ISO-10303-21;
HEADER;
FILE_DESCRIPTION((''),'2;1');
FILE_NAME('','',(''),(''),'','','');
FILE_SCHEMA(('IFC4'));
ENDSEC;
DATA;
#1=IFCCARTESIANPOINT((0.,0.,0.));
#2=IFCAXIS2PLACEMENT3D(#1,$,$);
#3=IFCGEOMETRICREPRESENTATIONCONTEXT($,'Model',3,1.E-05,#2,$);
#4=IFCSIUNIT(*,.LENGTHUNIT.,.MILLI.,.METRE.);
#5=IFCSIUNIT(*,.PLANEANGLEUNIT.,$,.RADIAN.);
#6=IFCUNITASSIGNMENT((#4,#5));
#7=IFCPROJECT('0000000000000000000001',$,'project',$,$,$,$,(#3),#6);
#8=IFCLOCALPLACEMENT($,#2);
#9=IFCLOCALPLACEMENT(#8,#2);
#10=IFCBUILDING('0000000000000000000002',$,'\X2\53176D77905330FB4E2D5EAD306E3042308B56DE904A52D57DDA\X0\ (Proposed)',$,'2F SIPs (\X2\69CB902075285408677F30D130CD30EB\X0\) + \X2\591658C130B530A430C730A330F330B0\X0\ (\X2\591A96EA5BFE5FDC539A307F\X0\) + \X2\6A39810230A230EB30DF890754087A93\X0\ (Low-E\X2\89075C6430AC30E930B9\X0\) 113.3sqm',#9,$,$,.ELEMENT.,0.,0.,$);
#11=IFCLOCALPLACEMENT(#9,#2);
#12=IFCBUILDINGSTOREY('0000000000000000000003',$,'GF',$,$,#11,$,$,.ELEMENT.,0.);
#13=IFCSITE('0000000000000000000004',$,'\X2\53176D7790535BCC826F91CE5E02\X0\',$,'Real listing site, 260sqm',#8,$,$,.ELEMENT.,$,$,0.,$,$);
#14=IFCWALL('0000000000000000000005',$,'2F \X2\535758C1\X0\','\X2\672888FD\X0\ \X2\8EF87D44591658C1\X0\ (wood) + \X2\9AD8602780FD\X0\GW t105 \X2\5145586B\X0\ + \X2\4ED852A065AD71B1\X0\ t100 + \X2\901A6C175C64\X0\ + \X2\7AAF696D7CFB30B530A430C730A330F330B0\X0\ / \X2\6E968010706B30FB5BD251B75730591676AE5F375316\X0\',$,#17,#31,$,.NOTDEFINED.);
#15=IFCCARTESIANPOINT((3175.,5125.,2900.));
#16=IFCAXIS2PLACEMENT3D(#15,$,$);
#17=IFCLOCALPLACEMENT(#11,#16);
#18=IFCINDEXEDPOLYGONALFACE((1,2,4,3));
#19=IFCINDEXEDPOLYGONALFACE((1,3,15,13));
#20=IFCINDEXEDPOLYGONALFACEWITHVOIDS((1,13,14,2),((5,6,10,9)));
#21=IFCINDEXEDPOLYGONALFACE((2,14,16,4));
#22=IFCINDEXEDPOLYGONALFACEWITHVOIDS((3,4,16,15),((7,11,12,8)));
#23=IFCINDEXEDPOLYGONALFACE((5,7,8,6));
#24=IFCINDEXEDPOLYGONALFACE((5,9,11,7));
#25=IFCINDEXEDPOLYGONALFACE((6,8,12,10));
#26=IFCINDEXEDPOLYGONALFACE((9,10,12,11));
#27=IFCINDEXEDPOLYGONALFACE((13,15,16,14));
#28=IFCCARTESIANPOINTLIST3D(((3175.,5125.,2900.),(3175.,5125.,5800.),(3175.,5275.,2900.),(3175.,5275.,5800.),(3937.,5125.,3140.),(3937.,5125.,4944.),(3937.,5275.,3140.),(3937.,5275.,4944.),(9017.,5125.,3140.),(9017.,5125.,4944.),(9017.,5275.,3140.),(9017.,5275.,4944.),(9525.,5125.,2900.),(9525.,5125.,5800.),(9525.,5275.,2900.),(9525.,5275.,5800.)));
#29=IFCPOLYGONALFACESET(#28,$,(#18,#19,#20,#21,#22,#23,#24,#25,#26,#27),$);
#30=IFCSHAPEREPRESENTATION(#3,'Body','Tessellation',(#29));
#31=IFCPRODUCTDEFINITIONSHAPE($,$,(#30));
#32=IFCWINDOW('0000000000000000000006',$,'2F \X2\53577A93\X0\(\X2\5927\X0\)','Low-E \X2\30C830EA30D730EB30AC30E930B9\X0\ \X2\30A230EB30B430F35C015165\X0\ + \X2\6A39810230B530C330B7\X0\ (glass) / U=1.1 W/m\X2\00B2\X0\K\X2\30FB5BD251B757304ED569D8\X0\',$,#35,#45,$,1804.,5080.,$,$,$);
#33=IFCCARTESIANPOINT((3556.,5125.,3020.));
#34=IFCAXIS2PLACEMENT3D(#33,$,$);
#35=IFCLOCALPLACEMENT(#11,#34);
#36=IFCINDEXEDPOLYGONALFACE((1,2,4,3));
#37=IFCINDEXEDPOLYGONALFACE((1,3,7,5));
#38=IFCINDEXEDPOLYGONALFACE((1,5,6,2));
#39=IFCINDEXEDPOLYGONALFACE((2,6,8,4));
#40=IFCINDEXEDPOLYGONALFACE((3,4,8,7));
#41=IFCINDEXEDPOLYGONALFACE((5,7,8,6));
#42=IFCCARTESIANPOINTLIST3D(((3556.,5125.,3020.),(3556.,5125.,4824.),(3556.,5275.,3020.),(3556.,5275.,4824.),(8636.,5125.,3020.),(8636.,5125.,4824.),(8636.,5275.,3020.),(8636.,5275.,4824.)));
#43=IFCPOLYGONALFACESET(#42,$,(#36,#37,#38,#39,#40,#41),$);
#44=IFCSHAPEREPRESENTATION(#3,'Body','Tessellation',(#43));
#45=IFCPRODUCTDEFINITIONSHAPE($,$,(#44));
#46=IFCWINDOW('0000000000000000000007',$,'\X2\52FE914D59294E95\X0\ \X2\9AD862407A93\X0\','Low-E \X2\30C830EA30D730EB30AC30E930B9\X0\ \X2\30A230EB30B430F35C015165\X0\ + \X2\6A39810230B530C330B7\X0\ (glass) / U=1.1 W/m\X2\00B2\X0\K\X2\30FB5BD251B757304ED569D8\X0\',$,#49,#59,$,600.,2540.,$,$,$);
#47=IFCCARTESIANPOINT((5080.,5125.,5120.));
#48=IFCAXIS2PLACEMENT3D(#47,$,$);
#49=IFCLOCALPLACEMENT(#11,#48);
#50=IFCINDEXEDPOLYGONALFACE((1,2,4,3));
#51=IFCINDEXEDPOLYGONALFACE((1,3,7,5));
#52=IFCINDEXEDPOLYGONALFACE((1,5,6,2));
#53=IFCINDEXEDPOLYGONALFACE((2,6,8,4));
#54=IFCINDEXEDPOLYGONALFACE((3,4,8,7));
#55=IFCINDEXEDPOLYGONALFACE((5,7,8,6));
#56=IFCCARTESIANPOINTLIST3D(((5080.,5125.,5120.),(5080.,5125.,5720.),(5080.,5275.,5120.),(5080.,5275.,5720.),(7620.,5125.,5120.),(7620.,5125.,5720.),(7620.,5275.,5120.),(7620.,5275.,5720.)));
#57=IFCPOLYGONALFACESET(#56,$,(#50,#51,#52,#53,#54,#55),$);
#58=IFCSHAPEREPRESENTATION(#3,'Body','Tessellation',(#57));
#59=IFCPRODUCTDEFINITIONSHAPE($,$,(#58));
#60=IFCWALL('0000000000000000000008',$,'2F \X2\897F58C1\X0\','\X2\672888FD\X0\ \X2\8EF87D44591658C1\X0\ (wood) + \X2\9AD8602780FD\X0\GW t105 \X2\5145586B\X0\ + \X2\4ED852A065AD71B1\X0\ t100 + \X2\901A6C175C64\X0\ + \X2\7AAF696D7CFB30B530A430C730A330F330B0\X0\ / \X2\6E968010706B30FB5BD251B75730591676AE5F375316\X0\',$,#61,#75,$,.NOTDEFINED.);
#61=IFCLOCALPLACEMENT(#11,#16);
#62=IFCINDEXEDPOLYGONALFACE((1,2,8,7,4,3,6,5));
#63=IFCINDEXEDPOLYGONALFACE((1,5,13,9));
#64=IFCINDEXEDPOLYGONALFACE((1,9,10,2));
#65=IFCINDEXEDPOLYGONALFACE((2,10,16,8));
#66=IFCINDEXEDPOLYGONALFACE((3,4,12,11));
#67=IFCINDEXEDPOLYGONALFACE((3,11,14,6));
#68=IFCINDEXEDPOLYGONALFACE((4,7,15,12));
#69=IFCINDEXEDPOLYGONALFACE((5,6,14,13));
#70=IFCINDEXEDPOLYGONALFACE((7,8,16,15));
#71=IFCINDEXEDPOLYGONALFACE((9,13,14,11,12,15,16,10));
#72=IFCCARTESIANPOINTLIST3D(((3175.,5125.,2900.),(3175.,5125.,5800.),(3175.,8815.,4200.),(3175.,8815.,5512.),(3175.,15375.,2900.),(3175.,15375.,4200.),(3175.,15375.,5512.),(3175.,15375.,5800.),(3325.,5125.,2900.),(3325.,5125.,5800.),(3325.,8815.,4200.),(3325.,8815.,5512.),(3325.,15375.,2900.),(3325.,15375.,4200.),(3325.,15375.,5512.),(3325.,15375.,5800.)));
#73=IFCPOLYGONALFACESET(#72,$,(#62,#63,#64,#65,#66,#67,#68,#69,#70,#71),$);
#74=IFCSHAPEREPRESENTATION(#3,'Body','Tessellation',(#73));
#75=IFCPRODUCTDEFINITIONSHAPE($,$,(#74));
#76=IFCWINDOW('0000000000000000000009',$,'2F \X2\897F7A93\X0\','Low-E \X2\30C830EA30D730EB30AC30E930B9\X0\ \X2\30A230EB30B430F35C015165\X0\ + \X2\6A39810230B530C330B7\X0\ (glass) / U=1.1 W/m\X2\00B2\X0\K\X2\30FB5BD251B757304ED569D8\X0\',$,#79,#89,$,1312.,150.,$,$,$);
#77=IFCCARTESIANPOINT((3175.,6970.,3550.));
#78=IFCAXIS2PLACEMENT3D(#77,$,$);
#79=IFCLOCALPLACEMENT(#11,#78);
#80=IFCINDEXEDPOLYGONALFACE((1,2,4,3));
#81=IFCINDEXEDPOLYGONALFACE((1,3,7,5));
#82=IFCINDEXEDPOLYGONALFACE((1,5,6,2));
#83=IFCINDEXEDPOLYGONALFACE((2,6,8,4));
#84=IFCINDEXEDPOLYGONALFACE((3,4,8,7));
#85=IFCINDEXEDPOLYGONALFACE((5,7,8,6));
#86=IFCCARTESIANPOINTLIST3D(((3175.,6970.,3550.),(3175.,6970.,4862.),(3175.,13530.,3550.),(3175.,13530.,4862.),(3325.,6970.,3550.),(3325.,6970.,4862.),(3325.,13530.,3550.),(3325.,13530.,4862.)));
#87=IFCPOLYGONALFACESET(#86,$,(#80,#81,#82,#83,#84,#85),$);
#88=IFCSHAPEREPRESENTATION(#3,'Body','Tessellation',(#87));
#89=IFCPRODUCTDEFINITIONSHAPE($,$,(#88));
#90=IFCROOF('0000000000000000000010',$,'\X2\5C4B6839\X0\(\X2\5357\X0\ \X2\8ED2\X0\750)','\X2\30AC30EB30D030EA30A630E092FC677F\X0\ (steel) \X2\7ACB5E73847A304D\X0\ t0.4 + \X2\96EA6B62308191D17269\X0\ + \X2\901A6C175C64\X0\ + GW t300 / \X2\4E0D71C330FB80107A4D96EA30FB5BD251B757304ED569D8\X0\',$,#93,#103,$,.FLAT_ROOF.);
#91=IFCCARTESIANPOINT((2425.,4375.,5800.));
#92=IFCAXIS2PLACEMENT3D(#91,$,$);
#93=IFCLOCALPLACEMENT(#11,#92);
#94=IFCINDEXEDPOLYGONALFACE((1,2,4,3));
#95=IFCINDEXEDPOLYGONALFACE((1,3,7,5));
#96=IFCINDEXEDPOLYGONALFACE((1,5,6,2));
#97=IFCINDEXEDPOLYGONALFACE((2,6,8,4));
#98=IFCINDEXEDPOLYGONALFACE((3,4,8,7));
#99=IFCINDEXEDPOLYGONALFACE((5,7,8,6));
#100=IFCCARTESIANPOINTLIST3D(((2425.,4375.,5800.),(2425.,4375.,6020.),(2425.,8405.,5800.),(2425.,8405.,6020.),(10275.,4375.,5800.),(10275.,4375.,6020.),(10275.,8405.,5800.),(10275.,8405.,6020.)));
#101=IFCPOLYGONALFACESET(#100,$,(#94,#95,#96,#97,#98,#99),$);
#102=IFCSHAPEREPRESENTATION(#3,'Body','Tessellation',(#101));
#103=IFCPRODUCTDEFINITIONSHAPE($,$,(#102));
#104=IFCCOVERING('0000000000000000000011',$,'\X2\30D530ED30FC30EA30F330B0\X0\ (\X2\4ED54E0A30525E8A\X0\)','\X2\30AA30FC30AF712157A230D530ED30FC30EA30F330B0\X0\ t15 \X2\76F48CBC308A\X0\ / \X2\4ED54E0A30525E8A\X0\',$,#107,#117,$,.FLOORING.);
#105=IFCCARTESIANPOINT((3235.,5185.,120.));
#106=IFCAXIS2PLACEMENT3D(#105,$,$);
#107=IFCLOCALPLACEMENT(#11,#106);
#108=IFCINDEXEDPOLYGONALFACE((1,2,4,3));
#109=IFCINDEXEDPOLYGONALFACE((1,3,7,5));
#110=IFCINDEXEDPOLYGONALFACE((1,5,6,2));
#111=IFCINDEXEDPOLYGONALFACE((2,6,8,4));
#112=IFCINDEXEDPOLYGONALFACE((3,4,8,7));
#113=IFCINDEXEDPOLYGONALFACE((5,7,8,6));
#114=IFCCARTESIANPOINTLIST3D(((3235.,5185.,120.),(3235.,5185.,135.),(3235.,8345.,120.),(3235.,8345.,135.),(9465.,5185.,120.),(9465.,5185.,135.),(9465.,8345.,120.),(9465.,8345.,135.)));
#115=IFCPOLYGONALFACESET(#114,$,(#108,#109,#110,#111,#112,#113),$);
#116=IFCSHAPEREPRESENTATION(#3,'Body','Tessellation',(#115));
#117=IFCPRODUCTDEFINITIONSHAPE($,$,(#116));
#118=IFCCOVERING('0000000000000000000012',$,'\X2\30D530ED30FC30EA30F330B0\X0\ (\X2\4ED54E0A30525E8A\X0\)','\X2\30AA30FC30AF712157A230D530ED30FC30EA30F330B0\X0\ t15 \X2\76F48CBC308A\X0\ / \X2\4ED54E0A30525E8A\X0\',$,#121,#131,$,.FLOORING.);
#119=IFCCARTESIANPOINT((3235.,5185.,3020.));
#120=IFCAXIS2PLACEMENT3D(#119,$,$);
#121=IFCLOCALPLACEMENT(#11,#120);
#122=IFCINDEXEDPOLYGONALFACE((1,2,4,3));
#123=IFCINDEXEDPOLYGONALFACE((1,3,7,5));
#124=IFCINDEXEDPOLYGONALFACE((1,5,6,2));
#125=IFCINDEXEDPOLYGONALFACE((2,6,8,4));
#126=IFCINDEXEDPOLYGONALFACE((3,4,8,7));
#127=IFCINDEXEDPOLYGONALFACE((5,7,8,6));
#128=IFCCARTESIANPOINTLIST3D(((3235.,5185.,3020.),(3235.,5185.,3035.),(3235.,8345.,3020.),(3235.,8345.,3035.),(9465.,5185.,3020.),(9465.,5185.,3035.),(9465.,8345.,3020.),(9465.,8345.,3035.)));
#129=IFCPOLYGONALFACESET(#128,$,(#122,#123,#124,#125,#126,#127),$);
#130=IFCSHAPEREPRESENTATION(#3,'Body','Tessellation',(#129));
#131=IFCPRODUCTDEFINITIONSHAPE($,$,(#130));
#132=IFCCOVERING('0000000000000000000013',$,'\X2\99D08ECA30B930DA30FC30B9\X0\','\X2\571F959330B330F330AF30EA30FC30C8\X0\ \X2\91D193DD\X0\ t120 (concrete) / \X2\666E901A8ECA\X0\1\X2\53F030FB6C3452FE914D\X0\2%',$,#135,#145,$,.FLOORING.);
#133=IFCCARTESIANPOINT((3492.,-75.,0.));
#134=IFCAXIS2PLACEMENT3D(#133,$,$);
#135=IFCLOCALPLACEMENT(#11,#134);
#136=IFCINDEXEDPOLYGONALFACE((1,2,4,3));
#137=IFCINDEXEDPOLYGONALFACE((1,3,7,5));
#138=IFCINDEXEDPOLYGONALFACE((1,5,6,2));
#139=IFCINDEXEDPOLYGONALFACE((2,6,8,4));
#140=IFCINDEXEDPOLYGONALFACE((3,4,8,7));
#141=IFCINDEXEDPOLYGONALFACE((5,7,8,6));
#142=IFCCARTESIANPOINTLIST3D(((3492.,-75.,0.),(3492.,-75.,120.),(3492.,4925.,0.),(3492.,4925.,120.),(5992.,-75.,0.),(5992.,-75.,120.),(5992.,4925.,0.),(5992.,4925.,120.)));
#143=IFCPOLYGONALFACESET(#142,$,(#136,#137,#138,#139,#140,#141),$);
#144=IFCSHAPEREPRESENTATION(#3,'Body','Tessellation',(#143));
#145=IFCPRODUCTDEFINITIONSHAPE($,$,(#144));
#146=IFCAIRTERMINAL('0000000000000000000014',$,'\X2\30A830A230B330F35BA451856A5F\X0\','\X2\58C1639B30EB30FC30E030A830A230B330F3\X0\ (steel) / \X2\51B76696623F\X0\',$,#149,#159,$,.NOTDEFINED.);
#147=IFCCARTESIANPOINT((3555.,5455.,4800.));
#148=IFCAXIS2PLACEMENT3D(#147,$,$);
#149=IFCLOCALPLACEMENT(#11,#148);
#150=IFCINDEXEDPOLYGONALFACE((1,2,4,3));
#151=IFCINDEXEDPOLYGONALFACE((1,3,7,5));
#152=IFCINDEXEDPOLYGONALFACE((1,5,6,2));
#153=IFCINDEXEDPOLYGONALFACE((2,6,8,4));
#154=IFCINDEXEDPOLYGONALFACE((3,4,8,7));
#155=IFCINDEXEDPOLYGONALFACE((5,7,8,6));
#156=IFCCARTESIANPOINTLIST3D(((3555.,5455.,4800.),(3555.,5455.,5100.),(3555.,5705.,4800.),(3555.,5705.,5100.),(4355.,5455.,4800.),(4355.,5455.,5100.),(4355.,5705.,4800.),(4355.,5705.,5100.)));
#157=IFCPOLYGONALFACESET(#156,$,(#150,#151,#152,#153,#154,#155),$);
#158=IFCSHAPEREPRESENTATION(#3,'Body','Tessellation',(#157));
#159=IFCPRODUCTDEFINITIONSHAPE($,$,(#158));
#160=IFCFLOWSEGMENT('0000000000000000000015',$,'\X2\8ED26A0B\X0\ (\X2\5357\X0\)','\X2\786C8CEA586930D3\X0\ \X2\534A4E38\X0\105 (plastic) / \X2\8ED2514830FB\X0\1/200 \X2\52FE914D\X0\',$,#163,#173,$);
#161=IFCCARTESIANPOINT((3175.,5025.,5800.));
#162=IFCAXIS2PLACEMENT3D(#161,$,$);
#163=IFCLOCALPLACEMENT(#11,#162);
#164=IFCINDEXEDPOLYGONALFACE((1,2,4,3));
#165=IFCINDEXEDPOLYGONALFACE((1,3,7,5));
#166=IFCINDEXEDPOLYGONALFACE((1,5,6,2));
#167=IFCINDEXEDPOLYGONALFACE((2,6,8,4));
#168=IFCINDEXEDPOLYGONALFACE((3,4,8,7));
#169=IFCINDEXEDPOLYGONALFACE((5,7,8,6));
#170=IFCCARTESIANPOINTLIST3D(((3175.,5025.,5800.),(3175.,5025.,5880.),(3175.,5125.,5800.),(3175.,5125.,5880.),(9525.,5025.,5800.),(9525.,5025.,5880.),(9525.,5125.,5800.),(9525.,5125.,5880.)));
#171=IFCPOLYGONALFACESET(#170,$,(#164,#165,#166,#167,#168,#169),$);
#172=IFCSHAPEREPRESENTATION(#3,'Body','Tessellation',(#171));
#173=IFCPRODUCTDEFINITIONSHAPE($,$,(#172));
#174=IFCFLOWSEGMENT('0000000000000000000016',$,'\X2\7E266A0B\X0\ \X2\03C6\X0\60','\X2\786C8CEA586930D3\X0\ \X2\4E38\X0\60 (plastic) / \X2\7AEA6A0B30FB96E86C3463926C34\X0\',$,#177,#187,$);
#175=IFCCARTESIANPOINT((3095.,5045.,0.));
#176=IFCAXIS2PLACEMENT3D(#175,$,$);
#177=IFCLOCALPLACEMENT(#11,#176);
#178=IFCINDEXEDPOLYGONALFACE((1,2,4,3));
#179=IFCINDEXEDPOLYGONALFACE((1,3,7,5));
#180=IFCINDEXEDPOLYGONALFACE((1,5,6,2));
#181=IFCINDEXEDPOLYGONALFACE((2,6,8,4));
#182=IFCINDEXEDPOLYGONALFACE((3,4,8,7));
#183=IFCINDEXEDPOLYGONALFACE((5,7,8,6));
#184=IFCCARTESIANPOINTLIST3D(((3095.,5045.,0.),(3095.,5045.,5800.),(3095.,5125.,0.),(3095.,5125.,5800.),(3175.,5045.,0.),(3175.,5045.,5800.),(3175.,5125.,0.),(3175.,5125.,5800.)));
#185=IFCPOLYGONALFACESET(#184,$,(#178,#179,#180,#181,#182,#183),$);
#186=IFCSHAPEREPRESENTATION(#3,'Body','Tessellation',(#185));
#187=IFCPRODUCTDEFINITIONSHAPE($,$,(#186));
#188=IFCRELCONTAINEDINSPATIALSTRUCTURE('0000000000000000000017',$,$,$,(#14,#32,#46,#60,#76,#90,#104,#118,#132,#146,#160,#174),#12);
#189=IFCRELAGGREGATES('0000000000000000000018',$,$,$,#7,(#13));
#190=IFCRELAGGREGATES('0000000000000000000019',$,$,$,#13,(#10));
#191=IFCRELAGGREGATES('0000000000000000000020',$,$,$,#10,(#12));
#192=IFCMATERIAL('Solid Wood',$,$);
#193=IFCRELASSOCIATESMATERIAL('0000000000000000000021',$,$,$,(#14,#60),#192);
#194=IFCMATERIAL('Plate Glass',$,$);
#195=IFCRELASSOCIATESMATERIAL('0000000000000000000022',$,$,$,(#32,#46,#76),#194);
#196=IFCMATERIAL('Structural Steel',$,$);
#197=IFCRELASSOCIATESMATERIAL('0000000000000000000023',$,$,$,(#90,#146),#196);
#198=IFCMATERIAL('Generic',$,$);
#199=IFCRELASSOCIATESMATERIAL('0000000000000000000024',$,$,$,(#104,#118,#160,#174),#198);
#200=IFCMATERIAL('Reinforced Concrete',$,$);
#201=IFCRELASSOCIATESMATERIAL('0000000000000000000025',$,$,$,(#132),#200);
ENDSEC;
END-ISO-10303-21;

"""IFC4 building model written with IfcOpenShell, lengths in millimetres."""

from ifc_helpers import new_model, si_unit, frame, frame_2d, origin, place, context, project, spatial, rectangle, extrude, material, element, fill, save


model = new_model("IFC4")

# Units and contexts
model_context = context("Model", 3, precision=1e-05, world=origin())
ifc_project = project(units=[si_unit("LENGTHUNIT", "METRE", prefix="MILLI"), si_unit("PLANEANGLEUNIT", "RADIAN")], contexts=[model_context])

# Site, building, storey
site_placement = place(None, origin())
site = spatial("IfcSite", under=ifc_project, at=site_placement, Name="北海道富良野市", ObjectType="Real listing site, 260sqm", CompositionType="ELEMENT", RefElevation=0.0)
building_placement = place(site_placement, origin())
building = spatial("IfcBuilding", under=site, at=building_placement, Name="北海道・中庭のある回遊動線 (Proposed)", ObjectType="2F SIPs (構造用合板パネル) + 外壁サイディング (多雪対応厚み) + 樹脂アルミ複合窓 (Low-E複層ガラス) 113.3sqm", CompositionType="ELEMENT", ElevationOfRefHeight=0.0, ElevationOfTerrain=0.0)
storey_placement = place(building_placement, origin())
storey = spatial("IfcBuildingStorey", under=building, at=storey_placement, Name="GF", CompositionType="ELEMENT", Elevation=0.0)

# Shared definitions
ifc_material_1 = material(Name="Solid Wood")

# Shared definitions
ifc_material_2 = material(Name="Reinforced Concrete")

# Shared definitions
ifc_material_3 = material(Name="Plate Glass")

# Wall, openings, windows
wall_1_placement = place(storey_placement, frame((3175.0, 5125.0, 2900.0)))
wall_1 = element("IfcWall", 1, at=wall_1_placement, inside=storey, material=ifc_material_1, Name="2F 南壁", Description="木製 軸組外壁 (wood) + 高性能GW t105 充填 + 付加断熱 t100 + 通気層 + 窯業系サイディング / 準耐火・寒冷地外皮強化", PredefinedType="NOTDEFINED", context=model_context, shape_type="SweptSolid", body=[
    extrude(rectangle(XDim=6350.0, YDim=150.0, at=frame_2d((3175.0, 75.0))), frame((3175.0, 5125.0, 2900.0)), (0.0, 0.0, 1.0), 2900.0),
])
opening_1_placement = place(storey_placement, frame((3556.0, 5125.0, 3020.0)))
opening_1 = element("IfcOpeningElement", 2, at=opening_1_placement, cuts=wall_1, PredefinedType="NOTDEFINED", context=model_context, shape_type="SweptSolid", body=[
    extrude(rectangle(XDim=5080.0, YDim=150.0, at=frame_2d((2540.0, 75.0))), frame((3556.0, 5125.0, 3020.0)), (0.0, 0.0, 1.0), 1804.0),
])
opening_2_placement = place(storey_placement, frame((5080.0, 5125.0, 5120.0)))
opening_2 = element("IfcOpeningElement", 3, at=opening_2_placement, cuts=wall_1, PredefinedType="NOTDEFINED", context=model_context, shape_type="SweptSolid", body=[
    extrude(rectangle(XDim=2540.0, YDim=150.0, at=frame_2d((1270.0, 75.0))), frame((5080.0, 5125.0, 5120.0)), (0.0, 0.0, 1.0), 600.0),
])
window_1_placement = place(storey_placement, frame((3556.0, 5125.0, 3020.0)))
window_1 = element("IfcWindow", 4, at=window_1_placement, inside=storey, material=ifc_material_3, Name="2F 南窓(大)", Description="Low-E トリプルガラス アルゴン封入 + 樹脂サッシ (glass) / U=1.1 W/m²K・寒冷地仕様", OverallHeight=1804.0, OverallWidth=5080.0, context=model_context, shape_type="SweptSolid", body=[
    extrude(rectangle(XDim=5080.0, YDim=150.0, at=frame_2d((2540.0, 75.0))), frame((3556.0, 5125.0, 3020.0)), (0.0, 0.0, 1.0), 1804.0),
])
fill(opening_1, window_1)
window_2_placement = place(storey_placement, frame((5080.0, 5125.0, 5120.0)))
window_2 = element("IfcWindow", 5, at=window_2_placement, inside=storey, material=ifc_material_3, Name="勾配天井 高所窓", Description="Low-E トリプルガラス アルゴン封入 + 樹脂サッシ (glass) / U=1.1 W/m²K・寒冷地仕様", OverallHeight=600.0, OverallWidth=2540.0, context=model_context, shape_type="SweptSolid", body=[
    extrude(rectangle(XDim=2540.0, YDim=150.0, at=frame_2d((1270.0, 75.0))), frame((5080.0, 5125.0, 5120.0)), (0.0, 0.0, 1.0), 600.0),
])
fill(opening_2, window_2)

# Wall, opening, window
wall_2_placement = place(storey_placement, frame((3175.0, 5125.0, 2900.0)))
wall_2 = element("IfcWall", 6, at=wall_2_placement, inside=storey, material=ifc_material_1, Name="2F 西壁", Description="木製 軸組外壁 (wood) + 高性能GW t105 充填 + 付加断熱 t100 + 通気層 + 窯業系サイディング / 準耐火・寒冷地外皮強化", PredefinedType="NOTDEFINED", context=model_context, shape_type="SweptSolid", body=[
    extrude(rectangle(XDim=150.0, YDim=10250.0, at=frame_2d((75.0, 5125.0))), frame((3175.0, 5125.0, 2900.0)), (0.0, 0.0, 1.0), 2900.0),
])
opening_3_placement = place(storey_placement, frame((3175.0, 6970.0, 3550.0)))
opening_3 = element("IfcOpeningElement", 7, at=opening_3_placement, cuts=wall_2, PredefinedType="NOTDEFINED", context=model_context, shape_type="SweptSolid", body=[
    extrude(rectangle(XDim=150.0, YDim=6560.0, at=frame_2d((75.0, 3280.0))), frame((3175.0, 6970.0, 3550.0)), (0.0, 0.0, 1.0), 1312.0),
])
window_3_placement = place(storey_placement, frame((3175.0, 6970.0, 3550.0)))
window_3 = element("IfcWindow", 8, at=window_3_placement, inside=storey, material=ifc_material_3, Name="2F 西窓", Description="Low-E トリプルガラス アルゴン封入 + 樹脂サッシ (glass) / U=1.1 W/m²K・寒冷地仕様", OverallHeight=1312.0, OverallWidth=150.0, context=model_context, shape_type="SweptSolid", body=[
    extrude(rectangle(XDim=150.0, YDim=6560.0, at=frame_2d((75.0, 3280.0))), frame((3175.0, 6970.0, 3550.0)), (0.0, 0.0, 1.0), 1312.0),
])
fill(opening_3, window_3)

# Roof
ifc_material_4 = material(Name="Structural Steel")
for number, where, name in (
    (9, (2425.0, 4375.0, 5800.0), "屋根(南 軒750)"),
):
    element("IfcRoof", number, at=place(storey_placement, frame(where)), inside=storey, material=ifc_material_4, Name=name, Description="ガルバリウム鋼板 (steel) 立平葺き t0.4 + 雪止め金物 + 通気層 + GW t300 / 不燃・耐積雪・寒冷地仕様", PredefinedType="FLAT_ROOF", context=model_context, shape_type="SweptSolid", body=[
        extrude(rectangle(XDim=7850.0, YDim=4030.0, at=frame_2d((3925.0, 2015.0))), frame((2425.0, 4375.0, 5800.0)), (0.0, 0.0, 1.0), 220.0),
    ])

# Coverings
ifc_material_5 = material(Name="Generic")
covering_1_placement = place(storey_placement, frame((3235.0, 5185.0, 120.0)))
element("IfcCovering", 10, at=covering_1_placement, inside=storey, material=ifc_material_5, Name="フローリング (仕上げ床)", Description="オーク無垢フローリング t15 直貼り / 仕上げ床", PredefinedType="FLOORING", context=model_context, shape_type="SweptSolid", body=[
    extrude(rectangle(XDim=6230.0, YDim=3160.0, at=frame_2d((3115.0, 1580.0))), frame((3235.0, 5185.0, 120.0)), (0.0, 0.0, 1.0), 15.0),
])
covering_2_placement = place(storey_placement, frame((3235.0, 5185.0, 3020.0)))
element("IfcCovering", 11, at=covering_2_placement, inside=storey, material=ifc_material_5, Name="フローリング (仕上げ床)", Description="オーク無垢フローリング t15 直貼り / 仕上げ床", PredefinedType="FLOORING", context=model_context, shape_type="SweptSolid", body=[
    extrude(rectangle(XDim=6230.0, YDim=3160.0, at=frame_2d((3115.0, 1580.0))), frame((3235.0, 5185.0, 3020.0)), (0.0, 0.0, 1.0), 15.0),
])
covering_3_placement = place(storey_placement, frame((3492.0, -75.0, 0.0)))
element("IfcCovering", 12, at=covering_3_placement, inside=storey, material=ifc_material_2, Name="駐車スペース", Description="土間コンクリート 金鏝 t120 (concrete) / 普通車1台・水勾配2%", PredefinedType="FLOORING", context=model_context, shape_type="SweptSolid", body=[
    extrude(rectangle(XDim=2500.0, YDim=5000.0, at=frame_2d((1250.0, 2500.0))), frame((3492.0, -75.0, 0.0)), (0.0, 0.0, 1.0), 120.0),
])

# Air terminal
air_terminal_placement = place(storey_placement, frame((3555.0, 5455.0, 4800.0)))
element("IfcAirTerminal", 13, at=air_terminal_placement, inside=storey, material=ifc_material_4, Name="エアコン室内機", Description="壁掛ルームエアコン (steel) / 冷暖房", PredefinedType="NOTDEFINED", context=model_context, shape_type="SweptSolid", body=[
    extrude(rectangle(XDim=800.0, YDim=250.0, at=frame_2d((400.0, 125.0))), frame((3555.0, 5455.0, 4800.0)), (0.0, 0.0, 1.0), 300.0),
])

# Flow segments
flow_segment_1_placement = place(storey_placement, frame((3175.0, 5025.0, 5800.0)))
element("IfcFlowSegment", 14, at=flow_segment_1_placement, inside=storey, material=ifc_material_5, Name="軒樋 (南)", Description="硬質塩ビ 半丸105 (plastic) / 軒先・1/200 勾配", context=model_context, shape_type="SweptSolid", body=[
    extrude(rectangle(XDim=6350.0, YDim=100.0, at=frame_2d((3175.0, 50.0))), frame((3175.0, 5025.0, 5800.0)), (0.0, 0.0, 1.0), 80.0),
])
flow_segment_2_placement = place(storey_placement, frame((3095.0, 5045.0, 0.0)))
element("IfcFlowSegment", 15, at=flow_segment_2_placement, inside=storey, material=ifc_material_5, Name="縦樋 φ60", Description="硬質塩ビ 丸60 (plastic) / 竪樋・雨水排水", context=model_context, shape_type="SweptSolid", body=[
    extrude(rectangle(XDim=80.0, YDim=80.0, at=frame_2d((40.0, 40.0))), frame((3095.0, 5045.0, 0.0)), (0.0, 0.0, 1.0), 5800.0),
])

save(model, "model.ifc")
